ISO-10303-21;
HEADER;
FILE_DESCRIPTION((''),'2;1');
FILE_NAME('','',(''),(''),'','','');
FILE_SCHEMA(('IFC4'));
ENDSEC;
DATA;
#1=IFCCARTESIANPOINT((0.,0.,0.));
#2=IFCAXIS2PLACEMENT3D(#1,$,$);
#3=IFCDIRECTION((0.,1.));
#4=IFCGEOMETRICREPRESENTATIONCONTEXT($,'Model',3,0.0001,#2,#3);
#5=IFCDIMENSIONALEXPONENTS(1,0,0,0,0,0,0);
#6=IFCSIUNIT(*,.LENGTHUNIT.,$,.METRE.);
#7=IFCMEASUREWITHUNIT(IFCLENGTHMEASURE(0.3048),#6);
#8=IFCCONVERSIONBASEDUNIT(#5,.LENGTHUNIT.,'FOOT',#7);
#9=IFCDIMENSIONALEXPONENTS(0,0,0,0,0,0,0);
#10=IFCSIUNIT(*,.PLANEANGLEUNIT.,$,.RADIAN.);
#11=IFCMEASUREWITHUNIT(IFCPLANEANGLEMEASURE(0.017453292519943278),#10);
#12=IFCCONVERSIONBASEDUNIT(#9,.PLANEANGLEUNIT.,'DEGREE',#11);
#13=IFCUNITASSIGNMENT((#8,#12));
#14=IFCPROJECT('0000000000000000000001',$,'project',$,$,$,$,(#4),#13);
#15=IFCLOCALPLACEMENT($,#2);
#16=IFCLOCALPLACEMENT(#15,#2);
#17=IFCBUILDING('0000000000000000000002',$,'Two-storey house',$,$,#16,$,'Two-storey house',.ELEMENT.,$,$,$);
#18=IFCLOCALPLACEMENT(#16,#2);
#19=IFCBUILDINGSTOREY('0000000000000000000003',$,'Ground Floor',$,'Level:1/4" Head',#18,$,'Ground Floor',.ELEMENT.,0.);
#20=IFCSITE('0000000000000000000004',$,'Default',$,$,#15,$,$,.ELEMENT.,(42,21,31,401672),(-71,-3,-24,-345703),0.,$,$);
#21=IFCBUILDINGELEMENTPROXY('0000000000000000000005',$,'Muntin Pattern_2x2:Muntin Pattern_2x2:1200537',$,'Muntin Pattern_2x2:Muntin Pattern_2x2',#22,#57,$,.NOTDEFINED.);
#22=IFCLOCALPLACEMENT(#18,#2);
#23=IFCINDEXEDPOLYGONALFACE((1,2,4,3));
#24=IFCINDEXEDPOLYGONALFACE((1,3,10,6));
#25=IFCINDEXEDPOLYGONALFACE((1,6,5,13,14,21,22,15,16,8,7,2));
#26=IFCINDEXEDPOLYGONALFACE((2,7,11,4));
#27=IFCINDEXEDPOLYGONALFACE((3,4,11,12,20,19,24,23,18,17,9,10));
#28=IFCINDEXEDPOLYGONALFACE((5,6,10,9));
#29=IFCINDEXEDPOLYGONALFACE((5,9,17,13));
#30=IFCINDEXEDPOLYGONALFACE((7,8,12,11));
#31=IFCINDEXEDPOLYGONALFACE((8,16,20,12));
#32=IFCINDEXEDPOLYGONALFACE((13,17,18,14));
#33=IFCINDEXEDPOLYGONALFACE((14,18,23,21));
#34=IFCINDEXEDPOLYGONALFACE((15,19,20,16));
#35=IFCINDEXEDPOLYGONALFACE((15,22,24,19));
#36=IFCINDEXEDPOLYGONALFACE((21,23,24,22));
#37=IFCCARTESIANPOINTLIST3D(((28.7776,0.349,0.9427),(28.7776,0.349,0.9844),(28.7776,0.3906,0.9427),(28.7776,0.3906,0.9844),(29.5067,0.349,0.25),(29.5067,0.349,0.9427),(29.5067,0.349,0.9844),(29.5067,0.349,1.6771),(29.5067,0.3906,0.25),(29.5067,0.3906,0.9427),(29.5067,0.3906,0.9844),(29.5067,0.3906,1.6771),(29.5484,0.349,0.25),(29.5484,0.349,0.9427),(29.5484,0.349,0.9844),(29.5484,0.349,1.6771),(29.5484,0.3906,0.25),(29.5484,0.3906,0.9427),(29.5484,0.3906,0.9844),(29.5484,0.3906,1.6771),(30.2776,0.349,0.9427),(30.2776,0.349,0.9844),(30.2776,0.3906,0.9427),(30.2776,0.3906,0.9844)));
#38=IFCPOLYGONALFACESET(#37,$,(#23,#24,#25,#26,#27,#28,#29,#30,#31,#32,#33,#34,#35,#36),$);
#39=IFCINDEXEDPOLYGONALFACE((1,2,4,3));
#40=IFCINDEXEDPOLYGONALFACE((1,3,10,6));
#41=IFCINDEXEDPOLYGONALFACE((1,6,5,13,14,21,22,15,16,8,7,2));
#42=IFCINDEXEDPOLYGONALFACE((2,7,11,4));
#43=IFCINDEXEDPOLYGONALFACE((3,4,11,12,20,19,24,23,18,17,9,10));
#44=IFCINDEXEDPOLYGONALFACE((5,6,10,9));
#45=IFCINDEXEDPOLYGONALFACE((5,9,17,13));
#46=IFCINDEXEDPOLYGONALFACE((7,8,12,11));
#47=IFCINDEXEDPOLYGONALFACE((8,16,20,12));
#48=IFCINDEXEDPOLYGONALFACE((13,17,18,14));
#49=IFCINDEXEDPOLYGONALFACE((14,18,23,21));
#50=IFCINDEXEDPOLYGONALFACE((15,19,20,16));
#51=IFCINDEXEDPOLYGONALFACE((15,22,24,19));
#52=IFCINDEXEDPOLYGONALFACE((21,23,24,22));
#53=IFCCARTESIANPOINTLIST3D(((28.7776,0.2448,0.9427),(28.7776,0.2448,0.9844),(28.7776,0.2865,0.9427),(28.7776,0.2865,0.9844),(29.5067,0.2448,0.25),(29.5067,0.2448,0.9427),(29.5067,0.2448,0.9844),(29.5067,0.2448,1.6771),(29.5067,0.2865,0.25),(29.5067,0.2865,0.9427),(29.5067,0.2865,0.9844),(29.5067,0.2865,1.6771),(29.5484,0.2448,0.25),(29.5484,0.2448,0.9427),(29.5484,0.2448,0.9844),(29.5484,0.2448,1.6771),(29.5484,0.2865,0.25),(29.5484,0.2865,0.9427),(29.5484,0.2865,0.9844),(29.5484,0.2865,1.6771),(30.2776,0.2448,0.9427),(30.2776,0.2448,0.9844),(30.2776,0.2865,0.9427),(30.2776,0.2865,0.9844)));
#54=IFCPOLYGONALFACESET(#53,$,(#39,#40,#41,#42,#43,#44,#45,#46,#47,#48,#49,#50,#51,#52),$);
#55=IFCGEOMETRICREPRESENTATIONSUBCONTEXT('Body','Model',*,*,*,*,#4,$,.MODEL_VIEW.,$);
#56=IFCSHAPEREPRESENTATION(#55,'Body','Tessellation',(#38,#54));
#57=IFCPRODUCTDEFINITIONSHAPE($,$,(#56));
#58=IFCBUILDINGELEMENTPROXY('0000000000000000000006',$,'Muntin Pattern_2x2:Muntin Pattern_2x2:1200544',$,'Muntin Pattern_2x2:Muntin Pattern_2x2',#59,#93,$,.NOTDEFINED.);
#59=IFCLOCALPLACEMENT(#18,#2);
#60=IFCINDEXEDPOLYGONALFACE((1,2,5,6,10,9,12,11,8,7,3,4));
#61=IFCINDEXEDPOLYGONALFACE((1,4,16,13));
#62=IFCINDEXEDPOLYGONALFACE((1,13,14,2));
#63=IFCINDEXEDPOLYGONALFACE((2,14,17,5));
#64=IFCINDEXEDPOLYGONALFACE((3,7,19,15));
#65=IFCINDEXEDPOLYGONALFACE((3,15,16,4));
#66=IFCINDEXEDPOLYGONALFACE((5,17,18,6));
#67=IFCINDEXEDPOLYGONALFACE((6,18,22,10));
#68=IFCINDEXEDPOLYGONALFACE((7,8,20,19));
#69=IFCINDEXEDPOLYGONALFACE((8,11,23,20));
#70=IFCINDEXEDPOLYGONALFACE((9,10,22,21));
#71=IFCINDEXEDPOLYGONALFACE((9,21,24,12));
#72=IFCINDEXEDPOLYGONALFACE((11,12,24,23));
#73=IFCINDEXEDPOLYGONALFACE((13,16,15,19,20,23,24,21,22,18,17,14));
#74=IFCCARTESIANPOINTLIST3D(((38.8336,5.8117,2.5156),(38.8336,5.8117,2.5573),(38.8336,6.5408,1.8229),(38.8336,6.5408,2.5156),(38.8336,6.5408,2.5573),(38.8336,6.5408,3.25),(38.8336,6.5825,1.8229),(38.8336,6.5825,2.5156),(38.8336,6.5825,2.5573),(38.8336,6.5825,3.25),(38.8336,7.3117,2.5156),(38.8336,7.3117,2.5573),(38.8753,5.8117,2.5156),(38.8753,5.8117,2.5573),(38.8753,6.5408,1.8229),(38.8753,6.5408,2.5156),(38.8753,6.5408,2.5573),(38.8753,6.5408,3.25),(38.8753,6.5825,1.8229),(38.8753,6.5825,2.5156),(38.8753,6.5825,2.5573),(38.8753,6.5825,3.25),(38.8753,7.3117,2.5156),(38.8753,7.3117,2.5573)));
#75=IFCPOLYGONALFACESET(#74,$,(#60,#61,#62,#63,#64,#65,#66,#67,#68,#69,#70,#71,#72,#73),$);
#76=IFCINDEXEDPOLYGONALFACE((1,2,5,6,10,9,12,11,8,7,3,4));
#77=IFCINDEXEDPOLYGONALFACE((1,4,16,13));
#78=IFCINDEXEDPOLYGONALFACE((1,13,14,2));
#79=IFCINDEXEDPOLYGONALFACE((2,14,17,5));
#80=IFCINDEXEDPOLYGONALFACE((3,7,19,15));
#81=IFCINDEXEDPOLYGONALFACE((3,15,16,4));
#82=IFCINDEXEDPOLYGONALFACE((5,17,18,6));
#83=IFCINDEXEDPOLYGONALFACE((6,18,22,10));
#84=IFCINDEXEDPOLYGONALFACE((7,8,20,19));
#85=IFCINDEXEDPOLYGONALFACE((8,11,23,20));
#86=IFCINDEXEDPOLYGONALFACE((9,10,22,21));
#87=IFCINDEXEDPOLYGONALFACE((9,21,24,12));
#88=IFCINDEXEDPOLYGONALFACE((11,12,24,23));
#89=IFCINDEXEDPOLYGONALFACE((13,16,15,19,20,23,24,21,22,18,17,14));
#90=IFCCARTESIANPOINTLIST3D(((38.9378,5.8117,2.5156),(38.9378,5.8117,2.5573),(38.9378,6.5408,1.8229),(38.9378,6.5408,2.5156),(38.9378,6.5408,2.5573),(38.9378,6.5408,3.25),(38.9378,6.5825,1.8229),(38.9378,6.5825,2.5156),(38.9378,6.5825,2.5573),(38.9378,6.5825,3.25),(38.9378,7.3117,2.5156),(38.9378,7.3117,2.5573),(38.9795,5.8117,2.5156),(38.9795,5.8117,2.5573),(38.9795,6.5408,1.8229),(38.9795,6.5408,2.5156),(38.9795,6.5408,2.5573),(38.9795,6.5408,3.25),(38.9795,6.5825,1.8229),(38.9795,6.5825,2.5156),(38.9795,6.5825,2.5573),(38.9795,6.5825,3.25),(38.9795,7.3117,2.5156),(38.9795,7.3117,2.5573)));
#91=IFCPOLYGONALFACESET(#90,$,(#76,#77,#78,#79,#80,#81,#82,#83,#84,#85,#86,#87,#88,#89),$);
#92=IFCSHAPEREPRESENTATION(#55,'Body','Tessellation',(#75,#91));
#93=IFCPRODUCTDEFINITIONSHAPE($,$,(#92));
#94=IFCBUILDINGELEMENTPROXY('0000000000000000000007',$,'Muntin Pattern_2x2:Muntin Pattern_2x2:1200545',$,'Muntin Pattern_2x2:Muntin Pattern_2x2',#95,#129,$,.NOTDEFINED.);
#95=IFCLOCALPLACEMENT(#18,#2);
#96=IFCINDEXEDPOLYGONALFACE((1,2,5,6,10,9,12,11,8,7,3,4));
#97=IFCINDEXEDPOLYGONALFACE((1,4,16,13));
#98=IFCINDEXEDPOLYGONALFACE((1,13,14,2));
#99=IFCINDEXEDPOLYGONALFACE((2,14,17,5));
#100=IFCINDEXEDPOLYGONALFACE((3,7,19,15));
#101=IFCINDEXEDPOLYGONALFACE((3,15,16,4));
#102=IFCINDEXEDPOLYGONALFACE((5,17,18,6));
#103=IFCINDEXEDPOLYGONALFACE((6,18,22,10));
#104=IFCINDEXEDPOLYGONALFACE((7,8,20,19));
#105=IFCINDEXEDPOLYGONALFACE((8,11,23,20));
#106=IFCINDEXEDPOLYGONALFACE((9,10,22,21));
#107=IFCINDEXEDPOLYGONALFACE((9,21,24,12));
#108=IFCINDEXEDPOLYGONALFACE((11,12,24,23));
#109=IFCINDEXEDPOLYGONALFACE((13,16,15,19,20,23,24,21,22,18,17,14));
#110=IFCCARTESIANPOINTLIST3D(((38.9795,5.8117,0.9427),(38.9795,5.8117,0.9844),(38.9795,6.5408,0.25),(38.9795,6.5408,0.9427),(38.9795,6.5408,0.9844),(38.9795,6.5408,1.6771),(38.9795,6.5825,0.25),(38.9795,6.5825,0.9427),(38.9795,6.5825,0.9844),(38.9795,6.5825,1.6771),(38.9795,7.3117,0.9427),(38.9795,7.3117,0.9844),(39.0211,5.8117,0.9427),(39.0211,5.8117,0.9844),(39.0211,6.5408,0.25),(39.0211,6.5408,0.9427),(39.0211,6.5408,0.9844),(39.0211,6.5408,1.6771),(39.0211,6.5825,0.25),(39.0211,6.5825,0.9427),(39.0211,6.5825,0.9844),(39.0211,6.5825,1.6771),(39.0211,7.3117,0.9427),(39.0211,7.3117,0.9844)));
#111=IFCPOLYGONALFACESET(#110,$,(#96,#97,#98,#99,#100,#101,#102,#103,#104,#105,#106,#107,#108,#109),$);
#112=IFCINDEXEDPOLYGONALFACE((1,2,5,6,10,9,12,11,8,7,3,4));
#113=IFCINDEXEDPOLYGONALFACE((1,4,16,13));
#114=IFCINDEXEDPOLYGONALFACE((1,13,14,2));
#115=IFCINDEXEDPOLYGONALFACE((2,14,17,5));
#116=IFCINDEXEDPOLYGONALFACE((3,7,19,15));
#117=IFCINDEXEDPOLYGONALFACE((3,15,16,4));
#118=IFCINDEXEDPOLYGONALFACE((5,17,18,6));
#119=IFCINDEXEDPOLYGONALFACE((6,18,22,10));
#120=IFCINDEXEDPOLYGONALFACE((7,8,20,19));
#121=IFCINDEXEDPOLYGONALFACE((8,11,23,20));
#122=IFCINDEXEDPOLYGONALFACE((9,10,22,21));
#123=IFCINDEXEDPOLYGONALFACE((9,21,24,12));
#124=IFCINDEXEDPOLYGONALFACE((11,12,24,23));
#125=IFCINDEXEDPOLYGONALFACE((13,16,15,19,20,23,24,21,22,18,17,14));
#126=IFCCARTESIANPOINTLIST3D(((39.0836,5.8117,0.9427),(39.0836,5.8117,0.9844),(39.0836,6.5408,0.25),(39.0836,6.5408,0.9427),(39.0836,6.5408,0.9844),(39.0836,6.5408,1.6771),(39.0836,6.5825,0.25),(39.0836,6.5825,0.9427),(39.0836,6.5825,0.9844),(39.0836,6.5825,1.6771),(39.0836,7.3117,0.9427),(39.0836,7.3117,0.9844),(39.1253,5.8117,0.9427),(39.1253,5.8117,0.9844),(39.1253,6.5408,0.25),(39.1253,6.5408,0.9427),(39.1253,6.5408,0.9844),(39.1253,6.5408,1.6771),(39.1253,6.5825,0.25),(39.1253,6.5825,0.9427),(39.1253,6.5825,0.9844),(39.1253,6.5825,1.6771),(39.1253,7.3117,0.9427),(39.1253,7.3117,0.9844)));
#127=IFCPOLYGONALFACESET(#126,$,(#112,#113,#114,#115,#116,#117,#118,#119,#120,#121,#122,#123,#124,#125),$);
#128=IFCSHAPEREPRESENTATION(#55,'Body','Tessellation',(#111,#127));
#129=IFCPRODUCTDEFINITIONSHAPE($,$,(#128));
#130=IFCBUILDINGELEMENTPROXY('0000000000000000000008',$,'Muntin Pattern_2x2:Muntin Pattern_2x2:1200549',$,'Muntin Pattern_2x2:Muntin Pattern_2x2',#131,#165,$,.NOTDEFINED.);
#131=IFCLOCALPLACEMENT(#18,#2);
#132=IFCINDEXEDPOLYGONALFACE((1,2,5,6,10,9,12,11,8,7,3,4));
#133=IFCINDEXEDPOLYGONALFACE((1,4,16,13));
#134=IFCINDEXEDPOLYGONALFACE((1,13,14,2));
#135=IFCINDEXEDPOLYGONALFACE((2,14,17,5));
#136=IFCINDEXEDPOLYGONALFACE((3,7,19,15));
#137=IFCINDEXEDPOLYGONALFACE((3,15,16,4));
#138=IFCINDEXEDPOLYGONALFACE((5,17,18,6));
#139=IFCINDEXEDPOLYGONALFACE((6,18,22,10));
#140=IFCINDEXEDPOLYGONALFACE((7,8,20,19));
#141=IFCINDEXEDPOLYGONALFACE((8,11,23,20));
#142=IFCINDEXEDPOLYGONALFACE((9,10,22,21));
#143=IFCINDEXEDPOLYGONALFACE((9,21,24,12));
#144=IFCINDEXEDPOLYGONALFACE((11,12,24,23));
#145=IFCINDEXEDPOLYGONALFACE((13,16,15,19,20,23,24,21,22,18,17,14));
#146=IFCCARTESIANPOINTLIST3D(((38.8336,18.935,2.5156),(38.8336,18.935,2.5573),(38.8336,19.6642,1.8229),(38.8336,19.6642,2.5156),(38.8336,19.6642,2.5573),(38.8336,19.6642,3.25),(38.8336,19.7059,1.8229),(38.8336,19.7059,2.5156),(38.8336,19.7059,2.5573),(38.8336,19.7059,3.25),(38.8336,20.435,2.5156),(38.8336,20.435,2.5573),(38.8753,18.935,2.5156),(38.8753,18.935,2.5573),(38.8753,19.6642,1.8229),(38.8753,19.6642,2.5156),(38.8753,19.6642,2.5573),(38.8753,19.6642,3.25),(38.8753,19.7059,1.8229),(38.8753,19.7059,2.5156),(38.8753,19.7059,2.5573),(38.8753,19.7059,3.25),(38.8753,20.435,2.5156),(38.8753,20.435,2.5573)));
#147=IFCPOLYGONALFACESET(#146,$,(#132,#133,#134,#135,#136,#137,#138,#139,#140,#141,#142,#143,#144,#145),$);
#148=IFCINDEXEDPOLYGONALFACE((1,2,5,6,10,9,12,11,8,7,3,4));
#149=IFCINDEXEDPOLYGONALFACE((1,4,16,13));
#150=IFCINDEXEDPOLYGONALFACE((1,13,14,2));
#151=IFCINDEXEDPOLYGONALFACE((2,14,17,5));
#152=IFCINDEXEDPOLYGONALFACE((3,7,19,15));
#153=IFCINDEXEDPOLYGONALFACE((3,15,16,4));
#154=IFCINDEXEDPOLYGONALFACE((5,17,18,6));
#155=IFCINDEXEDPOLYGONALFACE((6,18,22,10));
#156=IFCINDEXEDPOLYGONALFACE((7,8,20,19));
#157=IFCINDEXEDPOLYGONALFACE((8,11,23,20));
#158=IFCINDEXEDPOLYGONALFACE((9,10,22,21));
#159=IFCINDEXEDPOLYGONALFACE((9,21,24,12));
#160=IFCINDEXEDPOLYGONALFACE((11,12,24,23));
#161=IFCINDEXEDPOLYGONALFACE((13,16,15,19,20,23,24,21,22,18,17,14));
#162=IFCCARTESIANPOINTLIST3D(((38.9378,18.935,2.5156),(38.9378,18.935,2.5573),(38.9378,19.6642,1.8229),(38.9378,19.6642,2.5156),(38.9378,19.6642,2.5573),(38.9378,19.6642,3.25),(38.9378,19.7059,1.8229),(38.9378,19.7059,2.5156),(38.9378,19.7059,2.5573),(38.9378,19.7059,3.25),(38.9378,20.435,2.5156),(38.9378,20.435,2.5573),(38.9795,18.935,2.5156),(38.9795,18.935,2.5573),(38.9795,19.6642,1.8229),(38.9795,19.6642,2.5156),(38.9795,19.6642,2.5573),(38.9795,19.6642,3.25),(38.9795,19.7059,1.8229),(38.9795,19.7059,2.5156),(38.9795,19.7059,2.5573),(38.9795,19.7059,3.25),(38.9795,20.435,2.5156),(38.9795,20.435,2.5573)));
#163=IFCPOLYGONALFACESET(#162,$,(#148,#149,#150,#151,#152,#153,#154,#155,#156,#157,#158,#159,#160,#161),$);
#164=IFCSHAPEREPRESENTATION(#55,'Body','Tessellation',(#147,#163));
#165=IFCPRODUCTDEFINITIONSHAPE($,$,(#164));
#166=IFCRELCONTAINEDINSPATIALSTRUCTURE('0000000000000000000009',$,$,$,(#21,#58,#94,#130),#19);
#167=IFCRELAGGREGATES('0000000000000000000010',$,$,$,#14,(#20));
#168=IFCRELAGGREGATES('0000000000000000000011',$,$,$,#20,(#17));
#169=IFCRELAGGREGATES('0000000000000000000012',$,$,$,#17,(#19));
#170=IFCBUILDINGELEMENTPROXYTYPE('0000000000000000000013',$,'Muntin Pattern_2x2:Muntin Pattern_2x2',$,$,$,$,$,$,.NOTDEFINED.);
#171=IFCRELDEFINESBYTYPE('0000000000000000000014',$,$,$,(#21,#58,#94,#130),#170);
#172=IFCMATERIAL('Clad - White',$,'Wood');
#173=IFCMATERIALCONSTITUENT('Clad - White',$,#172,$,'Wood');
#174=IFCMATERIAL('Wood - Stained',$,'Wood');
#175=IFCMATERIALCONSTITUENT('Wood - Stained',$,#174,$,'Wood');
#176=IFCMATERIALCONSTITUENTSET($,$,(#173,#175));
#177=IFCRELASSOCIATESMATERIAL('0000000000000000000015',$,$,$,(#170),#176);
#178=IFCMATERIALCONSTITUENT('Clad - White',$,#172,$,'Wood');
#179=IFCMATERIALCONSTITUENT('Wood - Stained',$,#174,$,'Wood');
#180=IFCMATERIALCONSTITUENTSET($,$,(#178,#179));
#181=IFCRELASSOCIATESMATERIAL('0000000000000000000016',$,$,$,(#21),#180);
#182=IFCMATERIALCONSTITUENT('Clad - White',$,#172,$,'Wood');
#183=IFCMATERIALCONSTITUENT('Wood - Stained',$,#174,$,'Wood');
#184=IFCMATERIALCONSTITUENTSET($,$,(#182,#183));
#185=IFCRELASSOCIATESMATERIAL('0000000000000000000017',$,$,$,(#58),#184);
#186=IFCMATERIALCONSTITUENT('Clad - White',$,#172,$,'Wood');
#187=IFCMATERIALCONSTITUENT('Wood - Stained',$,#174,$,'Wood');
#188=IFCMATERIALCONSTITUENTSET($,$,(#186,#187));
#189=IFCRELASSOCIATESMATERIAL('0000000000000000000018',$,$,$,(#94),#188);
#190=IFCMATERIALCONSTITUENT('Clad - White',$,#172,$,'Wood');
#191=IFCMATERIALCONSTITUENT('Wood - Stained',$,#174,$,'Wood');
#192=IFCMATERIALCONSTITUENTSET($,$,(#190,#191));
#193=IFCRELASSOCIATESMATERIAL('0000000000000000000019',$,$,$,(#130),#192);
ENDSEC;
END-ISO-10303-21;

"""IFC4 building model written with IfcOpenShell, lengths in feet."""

from ifc_helpers import new_model, entity, si_unit, converted_unit, direction, frame, origin, place, context, subcontext, project, spatial, indexed_curve, outline, extrude, source, transform, mapped, material, constituent, constituent_set, type_object, type_shapes, element, save


model = new_model("IFC4")

# Units and contexts
model_context = context("Model", 3, precision=0.0001, world=origin(), true_north=direction((0.0, 1.0)))
body_context = subcontext(model_context, "Body", "Model", "MODEL_VIEW")
ifc_project = project(units=[converted_unit("LENGTHUNIT", "FOOT", entity("IfcLengthMeasure", 0.3048), si_unit("LENGTHUNIT", "METRE"), dimensions=[1, 0, 0, 0, 0, 0, 0]), converted_unit("PLANEANGLEUNIT", "DEGREE", entity("IfcPlaneAngleMeasure", 0.017453292519943278), si_unit("PLANEANGLEUNIT", "RADIAN"), dimensions=[0, 0, 0, 0, 0, 0, 0])], contexts=[model_context])

# Site, building, storey
site_placement = place(None, origin())
site = spatial("IfcSite", under=ifc_project, at=site_placement, Name="Default", CompositionType="ELEMENT", RefLatitude=(42, 21, 31, 401672), RefLongitude=(-71, -3, -24, -345703), RefElevation=0.0)
building_placement = place(site_placement, origin())
building = spatial("IfcBuilding", under=site, at=building_placement, Name="Two-storey house", LongName="Two-storey house", CompositionType="ELEMENT")
storey_placement = place(building_placement, origin())
storey = spatial("IfcBuildingStorey", under=building, at=storey_placement, Name="Ground Floor", ObjectType="Level:1/4\" Head", LongName="Ground Floor", CompositionType="ELEMENT", Elevation=0.0)

# Shared definitions
ifc_material_1 = material(Name="Wood - Stained", Category="Wood")

# Building element proxies
ifc_material_2 = material(Name="Clad - White", Category="Wood")
ifc_constituent_1 = constituent(ifc_material_2, Name="Clad - White", Category="Wood")
ifc_constituent_2 = constituent(ifc_material_1, Name="Wood - Stained", Category="Wood")
ifc_constituent_set_1 = constituent_set(constituents=[ifc_constituent_1, ifc_constituent_2])
ifc_constituent_3 = constituent(ifc_material_2, Name="Clad - White", Category="Wood")
ifc_constituent_4 = constituent(ifc_material_1, Name="Wood - Stained", Category="Wood")
ifc_constituent_set_2 = constituent_set(constituents=[ifc_constituent_3, ifc_constituent_4])
building_element_proxy_type_1 = type_object("IfcBuildingElementProxyType", Name="Muntin Pattern_2x2:Muntin Pattern_2x2", PredefinedType="NOTDEFINED", material=ifc_constituent_set_2)
shared_shape_1 = source(origin(), body_context, "Body", "SweptSolid", [
    extrude(outline(indexed_curve([(0.0208, -0.0208), (0.7135, -0.0208), (0.7135, 0.0208), (0.0208, 0.0208), (0.0208, 0.75), (-0.0208, 0.75), (-0.0208, 0.0208), (-0.7135, 0.0208), (-0.7135, -0.0208), (-0.0208, -0.0208), (-0.0208, -0.75), (0.0208, -0.75), (0.0208, -0.0208)], self_intersect=False)), frame((0.0, 0.0312, 0.7135), z_axis=(0.0, 1.0, 0.0), x_axis=(0.0, 0.0, 1.0)), (0.0, 0.0, 1.0), 0.0417),
    extrude(outline(indexed_curve([(0.0208, -0.0208), (0.7135, -0.0208), (0.7135, 0.0208), (0.0208, 0.0208), (0.0208, 0.75), (-0.0208, 0.75), (-0.0208, 0.0208), (-0.7135, 0.0208), (-0.7135, -0.0208), (-0.0208, -0.0208), (-0.0208, -0.75), (0.0208, -0.75), (0.0208, -0.0208)], self_intersect=False)), frame((0.0, -0.0729, 0.7135), z_axis=(0.0, 1.0, 0.0), x_axis=(0.0, 0.0, 1.0)), (0.0, 0.0, 1.0), 0.0417),
])
type_shapes(building_element_proxy_type_1, [shared_shape_1])
proxy_1_placement = place(storey_placement, frame((29.5276, 0.3177, 0.25)))
element("IfcBuildingElementProxy", 1, at=proxy_1_placement, inside=storey, type_object=building_element_proxy_type_1, material=ifc_constituent_set_1, Name="Muntin Pattern_2x2:Muntin Pattern_2x2:1200537", ObjectType="Muntin Pattern_2x2:Muntin Pattern_2x2", PredefinedType="NOTDEFINED", context=body_context, shape_type="MappedRepresentation", body=[
    mapped(shared_shape_1, transform((0.0, 0.0, 0.0), scale=1.0)),
])
ifc_constituent_5 = constituent(ifc_material_2, Name="Clad - White", Category="Wood")
ifc_constituent_6 = constituent(ifc_material_1, Name="Wood - Stained", Category="Wood")
ifc_constituent_set_3 = constituent_set(constituents=[ifc_constituent_5, ifc_constituent_6])
proxy_2_placement = place(storey_placement, frame((38.9065, 6.5617, 1.8229), z_axis=(0.0, 0.0, 1.0), x_axis=(0.0, 1.0, 0.0)))
element("IfcBuildingElementProxy", 2, at=proxy_2_placement, inside=storey, type_object=building_element_proxy_type_1, material=ifc_constituent_set_3, Name="Muntin Pattern_2x2:Muntin Pattern_2x2:1200544", ObjectType="Muntin Pattern_2x2:Muntin Pattern_2x2", PredefinedType="NOTDEFINED", context=body_context, shape_type="MappedRepresentation", body=[
    mapped(shared_shape_1, transform((0.0, 0.0, 0.0), scale=1.0)),
])
ifc_constituent_7 = constituent(ifc_material_2, Name="Clad - White", Category="Wood")
ifc_constituent_8 = constituent(ifc_material_1, Name="Wood - Stained", Category="Wood")
ifc_constituent_set_4 = constituent_set(constituents=[ifc_constituent_7, ifc_constituent_8])
proxy_3_placement = place(storey_placement, frame((39.0524, 6.5617, 0.25), z_axis=(0.0, 0.0, 1.0), x_axis=(0.0, 1.0, 0.0)))
element("IfcBuildingElementProxy", 3, at=proxy_3_placement, inside=storey, type_object=building_element_proxy_type_1, material=ifc_constituent_set_4, Name="Muntin Pattern_2x2:Muntin Pattern_2x2:1200545", ObjectType="Muntin Pattern_2x2:Muntin Pattern_2x2", PredefinedType="NOTDEFINED", context=body_context, shape_type="MappedRepresentation", body=[
    mapped(shared_shape_1, transform((0.0, 0.0, 0.0), scale=1.0)),
])
ifc_constituent_9 = constituent(ifc_material_2, Name="Clad - White", Category="Wood")
ifc_constituent_10 = constituent(ifc_material_1, Name="Wood - Stained", Category="Wood")
ifc_constituent_set_5 = constituent_set(constituents=[ifc_constituent_9, ifc_constituent_10])
proxy_4_placement = place(storey_placement, frame((38.9065, 19.685, 1.8229), z_axis=(0.0, 0.0, 1.0), x_axis=(0.0, 1.0, 0.0)))
element("IfcBuildingElementProxy", 4, at=proxy_4_placement, inside=storey, type_object=building_element_proxy_type_1, material=ifc_constituent_set_5, Name="Muntin Pattern_2x2:Muntin Pattern_2x2:1200549", ObjectType="Muntin Pattern_2x2:Muntin Pattern_2x2", PredefinedType="NOTDEFINED", context=body_context, shape_type="MappedRepresentation", body=[
    mapped(shared_shape_1, transform((0.0, 0.0, 0.0), scale=1.0)),
])

save(model, "model.ifc")
